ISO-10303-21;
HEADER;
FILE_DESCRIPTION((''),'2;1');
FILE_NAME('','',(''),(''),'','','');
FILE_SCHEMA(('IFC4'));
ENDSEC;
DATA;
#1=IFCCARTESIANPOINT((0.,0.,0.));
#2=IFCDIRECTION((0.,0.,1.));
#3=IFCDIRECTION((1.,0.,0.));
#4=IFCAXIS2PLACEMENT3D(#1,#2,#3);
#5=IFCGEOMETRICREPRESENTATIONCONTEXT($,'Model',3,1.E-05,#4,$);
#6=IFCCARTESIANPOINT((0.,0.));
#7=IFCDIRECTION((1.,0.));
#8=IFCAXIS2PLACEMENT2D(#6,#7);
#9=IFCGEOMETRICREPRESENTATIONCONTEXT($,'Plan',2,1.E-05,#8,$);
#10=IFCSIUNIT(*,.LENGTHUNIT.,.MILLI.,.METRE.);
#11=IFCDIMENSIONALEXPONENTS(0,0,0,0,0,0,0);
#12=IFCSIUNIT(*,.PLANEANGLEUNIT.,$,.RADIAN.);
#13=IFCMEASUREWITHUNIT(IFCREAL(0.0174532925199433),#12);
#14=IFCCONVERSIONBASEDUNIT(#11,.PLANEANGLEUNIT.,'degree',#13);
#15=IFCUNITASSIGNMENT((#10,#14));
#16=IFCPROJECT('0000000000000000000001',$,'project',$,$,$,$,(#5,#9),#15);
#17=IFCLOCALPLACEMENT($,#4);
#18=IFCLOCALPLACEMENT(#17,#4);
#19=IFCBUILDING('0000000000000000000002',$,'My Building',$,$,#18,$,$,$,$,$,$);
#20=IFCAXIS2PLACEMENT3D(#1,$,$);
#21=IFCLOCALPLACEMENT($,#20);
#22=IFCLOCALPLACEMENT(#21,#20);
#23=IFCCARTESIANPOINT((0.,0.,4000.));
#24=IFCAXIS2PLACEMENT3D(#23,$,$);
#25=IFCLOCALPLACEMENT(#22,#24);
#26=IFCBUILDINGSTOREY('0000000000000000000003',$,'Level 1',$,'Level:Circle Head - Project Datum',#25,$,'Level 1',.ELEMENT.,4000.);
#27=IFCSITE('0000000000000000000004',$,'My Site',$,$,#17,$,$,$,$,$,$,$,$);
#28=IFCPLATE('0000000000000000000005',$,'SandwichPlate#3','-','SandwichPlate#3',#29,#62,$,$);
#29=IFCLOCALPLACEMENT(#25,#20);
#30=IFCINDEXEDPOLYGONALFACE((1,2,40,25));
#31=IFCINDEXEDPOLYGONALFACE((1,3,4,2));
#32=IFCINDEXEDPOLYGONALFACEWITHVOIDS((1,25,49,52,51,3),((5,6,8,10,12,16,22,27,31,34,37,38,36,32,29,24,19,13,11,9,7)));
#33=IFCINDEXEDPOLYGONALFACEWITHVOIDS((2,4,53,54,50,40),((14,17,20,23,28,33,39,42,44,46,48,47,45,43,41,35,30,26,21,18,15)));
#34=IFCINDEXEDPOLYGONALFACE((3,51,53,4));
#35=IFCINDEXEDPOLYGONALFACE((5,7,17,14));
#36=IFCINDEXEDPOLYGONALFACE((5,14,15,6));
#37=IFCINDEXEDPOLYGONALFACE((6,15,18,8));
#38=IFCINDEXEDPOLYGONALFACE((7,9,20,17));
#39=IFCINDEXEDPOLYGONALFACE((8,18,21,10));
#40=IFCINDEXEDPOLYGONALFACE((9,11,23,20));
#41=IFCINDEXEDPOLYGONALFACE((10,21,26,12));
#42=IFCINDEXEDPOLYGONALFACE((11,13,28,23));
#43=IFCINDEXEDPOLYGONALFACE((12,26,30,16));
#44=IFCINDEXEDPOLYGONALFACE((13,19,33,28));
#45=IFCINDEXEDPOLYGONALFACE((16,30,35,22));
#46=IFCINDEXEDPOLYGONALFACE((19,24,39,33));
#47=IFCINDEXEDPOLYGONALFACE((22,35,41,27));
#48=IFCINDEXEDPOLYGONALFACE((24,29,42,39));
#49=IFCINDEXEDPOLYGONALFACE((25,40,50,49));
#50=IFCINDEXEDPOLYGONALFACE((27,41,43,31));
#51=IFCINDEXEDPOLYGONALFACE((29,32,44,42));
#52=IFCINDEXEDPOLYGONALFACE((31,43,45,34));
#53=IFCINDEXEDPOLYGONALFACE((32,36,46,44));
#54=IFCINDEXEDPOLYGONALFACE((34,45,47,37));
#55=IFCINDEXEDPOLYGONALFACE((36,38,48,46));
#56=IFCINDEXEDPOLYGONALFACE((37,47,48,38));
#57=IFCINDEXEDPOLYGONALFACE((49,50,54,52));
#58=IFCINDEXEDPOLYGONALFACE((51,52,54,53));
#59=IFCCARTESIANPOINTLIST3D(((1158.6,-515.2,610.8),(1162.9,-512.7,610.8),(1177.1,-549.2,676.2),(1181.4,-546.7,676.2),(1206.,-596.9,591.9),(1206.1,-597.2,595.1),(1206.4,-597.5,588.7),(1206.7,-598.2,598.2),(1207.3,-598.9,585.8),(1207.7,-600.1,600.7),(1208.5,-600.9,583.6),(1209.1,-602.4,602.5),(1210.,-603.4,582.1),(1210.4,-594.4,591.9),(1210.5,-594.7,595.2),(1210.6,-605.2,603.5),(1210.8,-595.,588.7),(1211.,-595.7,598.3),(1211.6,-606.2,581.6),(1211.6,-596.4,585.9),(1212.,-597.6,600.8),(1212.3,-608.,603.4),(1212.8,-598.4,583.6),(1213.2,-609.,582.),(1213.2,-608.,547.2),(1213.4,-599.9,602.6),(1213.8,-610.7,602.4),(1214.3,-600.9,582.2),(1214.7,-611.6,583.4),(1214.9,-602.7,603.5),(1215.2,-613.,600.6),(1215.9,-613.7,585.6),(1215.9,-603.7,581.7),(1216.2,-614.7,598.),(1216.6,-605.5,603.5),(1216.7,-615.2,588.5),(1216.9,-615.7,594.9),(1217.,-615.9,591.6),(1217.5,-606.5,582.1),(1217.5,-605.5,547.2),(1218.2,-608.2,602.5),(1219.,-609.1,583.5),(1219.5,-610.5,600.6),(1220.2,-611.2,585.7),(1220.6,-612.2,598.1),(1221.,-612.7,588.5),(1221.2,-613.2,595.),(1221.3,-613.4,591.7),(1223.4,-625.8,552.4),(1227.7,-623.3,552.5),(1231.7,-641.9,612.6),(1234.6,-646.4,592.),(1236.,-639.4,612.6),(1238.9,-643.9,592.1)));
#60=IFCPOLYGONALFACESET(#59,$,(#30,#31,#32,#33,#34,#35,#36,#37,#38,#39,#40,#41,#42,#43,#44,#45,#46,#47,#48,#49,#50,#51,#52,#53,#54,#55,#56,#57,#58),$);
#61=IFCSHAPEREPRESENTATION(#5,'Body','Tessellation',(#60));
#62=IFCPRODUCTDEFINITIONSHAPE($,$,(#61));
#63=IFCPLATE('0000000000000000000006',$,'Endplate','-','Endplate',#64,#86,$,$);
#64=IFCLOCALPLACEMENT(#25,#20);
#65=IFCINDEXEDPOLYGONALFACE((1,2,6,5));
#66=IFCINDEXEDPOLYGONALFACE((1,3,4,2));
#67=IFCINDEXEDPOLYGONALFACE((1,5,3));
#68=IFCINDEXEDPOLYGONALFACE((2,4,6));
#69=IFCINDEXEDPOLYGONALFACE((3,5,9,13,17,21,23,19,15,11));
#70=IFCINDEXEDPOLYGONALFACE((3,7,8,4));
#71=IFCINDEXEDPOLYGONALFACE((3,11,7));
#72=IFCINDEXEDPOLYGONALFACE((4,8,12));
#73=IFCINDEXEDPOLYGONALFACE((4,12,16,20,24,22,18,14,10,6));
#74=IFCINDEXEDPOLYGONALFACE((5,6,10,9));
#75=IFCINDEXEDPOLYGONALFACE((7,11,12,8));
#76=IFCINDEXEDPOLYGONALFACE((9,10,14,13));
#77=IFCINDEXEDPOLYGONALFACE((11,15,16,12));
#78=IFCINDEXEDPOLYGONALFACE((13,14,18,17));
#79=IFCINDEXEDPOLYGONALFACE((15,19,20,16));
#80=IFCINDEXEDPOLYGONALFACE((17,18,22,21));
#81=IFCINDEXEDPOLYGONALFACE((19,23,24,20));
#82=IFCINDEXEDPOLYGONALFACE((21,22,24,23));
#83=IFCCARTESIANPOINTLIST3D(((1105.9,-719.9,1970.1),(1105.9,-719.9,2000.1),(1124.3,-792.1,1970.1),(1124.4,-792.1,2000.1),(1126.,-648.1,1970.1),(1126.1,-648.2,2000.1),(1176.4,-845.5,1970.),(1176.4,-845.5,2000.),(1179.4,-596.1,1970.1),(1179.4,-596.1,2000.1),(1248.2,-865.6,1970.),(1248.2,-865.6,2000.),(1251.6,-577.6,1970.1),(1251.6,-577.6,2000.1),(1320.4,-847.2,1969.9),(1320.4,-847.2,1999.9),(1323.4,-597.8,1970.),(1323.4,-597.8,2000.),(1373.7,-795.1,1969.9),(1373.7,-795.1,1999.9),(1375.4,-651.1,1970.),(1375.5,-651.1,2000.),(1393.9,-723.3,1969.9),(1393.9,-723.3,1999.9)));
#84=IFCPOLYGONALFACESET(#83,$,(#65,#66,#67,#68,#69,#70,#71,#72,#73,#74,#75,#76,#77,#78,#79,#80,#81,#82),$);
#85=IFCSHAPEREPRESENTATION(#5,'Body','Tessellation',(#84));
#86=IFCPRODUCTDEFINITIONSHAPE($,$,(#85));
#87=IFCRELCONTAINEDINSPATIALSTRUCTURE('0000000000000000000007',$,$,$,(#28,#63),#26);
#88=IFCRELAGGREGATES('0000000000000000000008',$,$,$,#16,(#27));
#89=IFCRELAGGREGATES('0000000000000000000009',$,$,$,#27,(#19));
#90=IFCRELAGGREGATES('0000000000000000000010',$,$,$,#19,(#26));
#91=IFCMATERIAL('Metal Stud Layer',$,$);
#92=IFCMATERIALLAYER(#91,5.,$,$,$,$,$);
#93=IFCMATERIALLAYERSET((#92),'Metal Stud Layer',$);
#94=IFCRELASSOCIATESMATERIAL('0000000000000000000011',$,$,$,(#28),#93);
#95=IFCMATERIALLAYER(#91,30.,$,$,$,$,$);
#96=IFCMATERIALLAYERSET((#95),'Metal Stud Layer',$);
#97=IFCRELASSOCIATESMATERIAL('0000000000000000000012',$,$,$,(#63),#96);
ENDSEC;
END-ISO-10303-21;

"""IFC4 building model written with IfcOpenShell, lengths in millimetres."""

from ifc_helpers import new_model, entity, si_unit, converted_unit, point, frame, frame_2d, origin, origin_with_axes, origin_2d_with_axis, place, context, project, spatial, polyline, circle_curve, line_curve, trimmed, segment, composite_curve, circle, outline, extrude, material, layer, layer_set, element, save


model = new_model("IFC4")

# Units and contexts
model_context = context("Model", 3, precision=1e-05, world=origin_with_axes())
plan_context = context("Plan", 2, precision=1e-05, world=origin_2d_with_axis())
ifc_project = project(units=[si_unit("LENGTHUNIT", "METRE", prefix="MILLI"), converted_unit("PLANEANGLEUNIT", "degree", entity("IfcReal", 0.0174532925199433), si_unit("PLANEANGLEUNIT", "RADIAN"), dimensions=[0, 0, 0, 0, 0, 0, 0])], contexts=[model_context, plan_context])

# Site, building, storey
site_placement = place(None, origin_with_axes())
site = spatial("IfcSite", under=ifc_project, at=site_placement, Name="My Site")
building_placement = place(site_placement, origin_with_axes())
building = spatial("IfcBuilding", under=site, at=building_placement, Name="My Building")
placement_1 = place(None, origin())
placement_2 = place(placement_1, origin())
storey_placement = place(placement_2, frame((0.0, 0.0, 4000.0)))
storey = spatial("IfcBuildingStorey", under=building, at=storey_placement, Name="Level 1", ObjectType="Level:Circle Head - Project Datum", LongName="Level 1", CompositionType="ELEMENT", Elevation=4000.0)

# Shared definitions
ifc_material_1 = material(Name="Metal Stud Layer")

# Shared definitions
ifc_layer_1 = layer(ifc_material_1, 5.0)
ifc_layer_set_1 = layer_set([ifc_layer_1], Name="Metal Stud Layer")

# Plates, openings
plate_1_placement = place(storey_placement, frame((1224.1, -616.6, 539.6), z_axis=(-0.865935, -0.499948, -0.014432), x_axis=(0.243701, -0.44695, 0.860724)))
plate_1 = element("IfcPlate", 1, at=plate_1_placement, inside=storey, material=ifc_layer_set_1, Name="SandwichPlate#3", Description="-", ObjectType="SandwichPlate#3", context=model_context, shape_type="SweptSolid", body=[
    extrude(outline(polyline([(0.0, 0.0), (76.0, 0.0), (76.0, 140.0), (0.0, 140.0), (0.0, 0.0)])), origin_with_axes(), (0.0, 0.0, 1.0), 5.0),
])
opening_1_placement = place(plate_1_placement, frame((0.0, 0.0, 0.0), z_axis=(0.0, 0.0, 1.0), x_axis=(1.0, 0.0, 0.0)))
element("IfcOpeningElement", 2, at=opening_1_placement, cuts=plate_1, ObjectType="Opening", context=model_context, shape_type="SweptSolid", body=[
    extrude(outline(polyline([(0.0, 0.0), (15.0, 0.0), (0.0, 15.0), (0.0, 0.0)])), origin(), (0.0, 0.0, 1.0), 5.0),
])
opening_2_placement = place(plate_1_placement, frame((0.0, 0.0, 0.0), z_axis=(0.0, 0.0, 1.0), x_axis=(1.0, 0.0, 0.0)))
element("IfcOpeningElement", 3, at=opening_2_placement, cuts=plate_1, ObjectType="Opening", context=model_context, shape_type="SweptSolid", body=[
    extrude(outline(polyline([(76.0, 0.0), (76.0, 15.0), (61.0, 0.0), (76.0, 0.0)])), origin(), (0.0, 0.0, 1.0), 5.0),
])
opening_3_placement = place(plate_1_placement, frame((38.0, 40.0, -0.5), z_axis=(0.0, 0.0, 1.0), x_axis=(0.0, 1.0, 0.0)))
element("IfcOpeningElement", 4, at=opening_3_placement, cuts=plate_1, ObjectType="Opening", context=model_context, shape_type="SweptSolid", body=[
    extrude(circle(Radius=11.0, at=origin_2d_with_axis()), origin(), (0.0, 0.0, 1.0), 6.0),
])
ifc_layer_2 = layer(ifc_material_1, 30.0)
ifc_layer_set_2 = layer_set([ifc_layer_2], Name="Metal Stud Layer")
plate_2_placement = place(storey_placement, frame((1323.4, -597.8, 1970.0), z_axis=(0.000702, -0.000406, 1.0), x_axis=(-0.860023, 0.510255, 0.000811)))
plate_2 = element("IfcPlate", 5, at=plate_2_placement, inside=storey, material=ifc_layer_set_2, Name="Endplate", Description="-", ObjectType="Endplate", context=model_context, shape_type="SweptSolid", body=[
    extrude(outline(polyline([(144.0, 0.0), (144.0, 288.0), (-144.0, 288.0), (-144.0, 0.0), (144.0, 0.0)])), origin_with_axes(), (0.0, 0.0, 1.0), 30.0),
])
opening_4_placement = place(plate_2_placement, frame((0.0, 0.0, 0.0), z_axis=(0.0, 0.0, 1.0), x_axis=(1.0, 0.0, 0.0)))
element("IfcOpeningElement", 6, at=opening_4_placement, cuts=plate_2, ObjectType="Opening", context=model_context, shape_type="SweptSolid", body=[
    extrude(outline(composite_curve([segment(trimmed(line_curve((-144.0, 0.0), (1.0, 0.0), 144.0), [point((-144.0, 0.0))], [point((0.0, 0.0))], True, "CARTESIAN"), True, "CONTINUOUS"), segment(trimmed(circle_curve(frame_2d((0.0, 144.0), x_axis=(-1.0, 0.0)), 144.0), [point((0.0, 0.0))], [point((-144.0, 144.0))], False, "CARTESIAN"), True, "CONTINUOUS"), segment(trimmed(line_curve((-144.0, 144.0), (0.0, -1.0), 144.0), [point((-144.0, 144.0))], [point((-144.0, 0.0))], True, "CARTESIAN"), True, "CONTINUOUS")], self_intersect=False)), origin(), (0.0, 0.0, 1.0), 30.0),
])
opening_5_placement = place(plate_2_placement, frame((0.0, 0.0, 0.0), z_axis=(0.0, 0.0, 1.0), x_axis=(1.0, 0.0, 0.0)))
element("IfcOpeningElement", 7, at=opening_5_placement, cuts=plate_2, ObjectType="Opening", context=model_context, shape_type="SweptSolid", body=[
    extrude(outline(composite_curve([segment(trimmed(line_curve((144.0, 288.0), (-1.0, 0.0), 144.0), [point((144.0, 288.0))], [point((0.0, 288.0))], True, "CARTESIAN"), True, "CONTINUOUS"), segment(trimmed(circle_curve(frame_2d((0.0, 144.0), x_axis=(-1.0, 0.0)), 144.0), [point((0.0, 288.0))], [point((144.0, 144.0))], False, "CARTESIAN"), True, "CONTINUOUS"), segment(trimmed(line_curve((144.0, 144.0), (0.0, 1.0), 144.0), [point((144.0, 144.0))], [point((144.0, 288.0))], True, "CARTESIAN"), True, "CONTINUOUS")], self_intersect=False)), origin(), (0.0, 0.0, 1.0), 30.0),
])
opening_6_placement = place(plate_2_placement, frame((0.0, 0.0, 0.0), z_axis=(0.0, 0.0, 1.0), x_axis=(1.0, 0.0, 0.0)))
element("IfcOpeningElement", 8, at=opening_6_placement, cuts=plate_2, ObjectType="Opening", context=model_context, shape_type="SweptSolid", body=[
    extrude(outline(composite_curve([segment(trimmed(line_curve((-144.0, 288.0), (0.0, -1.0), 144.0), [point((-144.0, 288.0))], [point((-144.0, 144.0))], True, "CARTESIAN"), True, "CONTINUOUS"), segment(trimmed(circle_curve(frame_2d((0.0, 144.0), x_axis=(-1.0, 0.0)), 144.0), [point((-144.0, 144.0))], [point((0.0, 288.0))], False, "CARTESIAN"), True, "CONTINUOUS"), segment(trimmed(line_curve((0.0, 288.0), (-1.0, 0.0), 144.0), [point((0.0, 288.0))], [point((-144.0, 288.0))], True, "CARTESIAN"), True, "CONTINUOUS")], self_intersect=False)), origin(), (0.0, 0.0, 1.0), 30.0),
])
opening_7_placement = place(plate_2_placement, frame((0.0, 0.0, 0.0), z_axis=(0.0, 0.0, 1.0), x_axis=(1.0, 0.0, 0.0)))
element("IfcOpeningElement", 9, at=opening_7_placement, cuts=plate_2, ObjectType="Opening", context=model_context, shape_type="SweptSolid", body=[
    extrude(outline(composite_curve([segment(trimmed(line_curve((144.0, 0.0), (0.0, 1.0), 144.0), [point((144.0, 0.0))], [point((144.0, 144.0))], True, "CARTESIAN"), True, "CONTINUOUS"), segment(trimmed(circle_curve(frame_2d((0.0, 144.0), x_axis=(-1.0, 0.0)), 144.0), [point((144.0, 144.0))], [point((0.0, 0.0))], False, "CARTESIAN"), True, "CONTINUOUS"), segment(trimmed(line_curve((0.0, 0.0), (1.0, 0.0), 144.0), [point((0.0, 0.0))], [point((144.0, 0.0))], True, "CARTESIAN"), True, "CONTINUOUS")], self_intersect=False)), origin(), (0.0, 0.0, 1.0), 30.0),
])

save(model, "model.ifc")
